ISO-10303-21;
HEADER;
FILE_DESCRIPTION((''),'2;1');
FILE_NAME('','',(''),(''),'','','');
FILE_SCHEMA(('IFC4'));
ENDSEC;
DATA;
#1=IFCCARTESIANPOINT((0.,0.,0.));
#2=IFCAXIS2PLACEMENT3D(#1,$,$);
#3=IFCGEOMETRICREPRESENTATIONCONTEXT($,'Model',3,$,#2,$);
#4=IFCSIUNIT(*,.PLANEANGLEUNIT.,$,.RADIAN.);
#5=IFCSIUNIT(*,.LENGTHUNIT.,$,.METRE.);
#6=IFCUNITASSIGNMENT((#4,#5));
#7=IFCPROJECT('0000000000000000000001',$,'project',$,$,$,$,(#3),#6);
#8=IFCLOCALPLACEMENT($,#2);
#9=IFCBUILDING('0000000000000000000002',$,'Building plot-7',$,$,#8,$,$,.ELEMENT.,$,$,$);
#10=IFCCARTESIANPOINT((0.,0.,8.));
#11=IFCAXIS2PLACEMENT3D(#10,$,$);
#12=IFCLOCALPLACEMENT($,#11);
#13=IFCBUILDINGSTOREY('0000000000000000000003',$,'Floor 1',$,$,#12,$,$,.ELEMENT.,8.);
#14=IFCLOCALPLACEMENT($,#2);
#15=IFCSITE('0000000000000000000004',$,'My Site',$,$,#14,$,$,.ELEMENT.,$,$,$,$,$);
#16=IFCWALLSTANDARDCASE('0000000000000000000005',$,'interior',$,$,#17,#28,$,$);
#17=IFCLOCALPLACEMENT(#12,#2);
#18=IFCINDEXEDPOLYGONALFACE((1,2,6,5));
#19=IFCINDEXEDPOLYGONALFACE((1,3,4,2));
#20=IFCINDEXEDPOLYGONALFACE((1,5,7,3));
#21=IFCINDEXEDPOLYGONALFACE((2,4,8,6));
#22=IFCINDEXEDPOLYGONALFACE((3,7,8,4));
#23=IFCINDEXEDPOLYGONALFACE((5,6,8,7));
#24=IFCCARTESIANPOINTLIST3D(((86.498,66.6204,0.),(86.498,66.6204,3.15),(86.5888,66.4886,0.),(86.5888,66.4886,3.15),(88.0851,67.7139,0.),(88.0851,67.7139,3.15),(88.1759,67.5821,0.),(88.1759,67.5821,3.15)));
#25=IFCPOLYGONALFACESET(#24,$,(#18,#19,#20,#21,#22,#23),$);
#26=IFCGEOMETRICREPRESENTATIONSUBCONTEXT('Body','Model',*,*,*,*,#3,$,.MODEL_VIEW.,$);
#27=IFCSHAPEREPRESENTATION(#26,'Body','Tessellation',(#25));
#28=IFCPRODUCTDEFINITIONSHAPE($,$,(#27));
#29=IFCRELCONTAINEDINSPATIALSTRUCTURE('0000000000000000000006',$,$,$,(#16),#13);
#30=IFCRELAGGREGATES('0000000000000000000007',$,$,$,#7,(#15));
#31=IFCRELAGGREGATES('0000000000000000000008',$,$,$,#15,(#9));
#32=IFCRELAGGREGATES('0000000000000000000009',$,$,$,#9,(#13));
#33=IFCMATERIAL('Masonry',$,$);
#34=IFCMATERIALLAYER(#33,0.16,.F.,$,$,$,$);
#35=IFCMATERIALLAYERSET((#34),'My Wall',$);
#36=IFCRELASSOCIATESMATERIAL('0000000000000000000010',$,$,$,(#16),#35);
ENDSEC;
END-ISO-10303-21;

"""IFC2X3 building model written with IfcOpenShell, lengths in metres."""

from ifc_helpers import new_model, si_unit, frame, origin, place, context, subcontext, project, spatial, polyline, outline, extrude, material, layer, layer_set, layer_usage, element, save


model = new_model("IFC2X3")

# Units and contexts
model_context = context("Model", 3, world=origin())
body_context = subcontext(model_context, "Body", "Model", "MODEL_VIEW")
ifc_project = project(units=[si_unit("PLANEANGLEUNIT", "RADIAN"), si_unit("LENGTHUNIT", "METRE")], contexts=[model_context])

# Site, building, storey
site_placement = place(None, origin())
site = spatial("IfcSite", under=ifc_project, at=site_placement, Name="My Site", CompositionType="ELEMENT")
building_placement = place(None, origin())
building = spatial("IfcBuilding", under=site, at=building_placement, Name="Building plot-7", CompositionType="ELEMENT")
storey_placement = place(None, frame((0.0, 0.0, 8.0)))
storey = spatial("IfcBuildingStorey", under=building, at=storey_placement, Name="Floor 1", CompositionType="ELEMENT", Elevation=8.0)

# Shared definitions
ifc_material = material(Name="Masonry")
ifc_layer = layer(ifc_material, 0.16, ventilated=False)
ifc_layer_set = layer_set([ifc_layer], Name="My Wall")
ifc_layer_usage = layer_usage(ifc_layer_set, "AXIS2", "NEGATIVE", 0.08)

# Wall
wall_1_placement = place(storey_placement, origin())
element("IfcWallStandardCase", 1, at=wall_1_placement, inside=storey, material=ifc_layer_usage, Name="interior", context=body_context, shape_type="SweptSolid", body=[
    extrude(outline(polyline([(86.498, 66.6204), (86.5888, 66.4886), (88.1759, 67.5821), (88.0851, 67.7139), (86.498, 66.6204)])), origin(), (0.0, 0.0, 1.0), 3.15),
])

save(model, "model.ifc")
